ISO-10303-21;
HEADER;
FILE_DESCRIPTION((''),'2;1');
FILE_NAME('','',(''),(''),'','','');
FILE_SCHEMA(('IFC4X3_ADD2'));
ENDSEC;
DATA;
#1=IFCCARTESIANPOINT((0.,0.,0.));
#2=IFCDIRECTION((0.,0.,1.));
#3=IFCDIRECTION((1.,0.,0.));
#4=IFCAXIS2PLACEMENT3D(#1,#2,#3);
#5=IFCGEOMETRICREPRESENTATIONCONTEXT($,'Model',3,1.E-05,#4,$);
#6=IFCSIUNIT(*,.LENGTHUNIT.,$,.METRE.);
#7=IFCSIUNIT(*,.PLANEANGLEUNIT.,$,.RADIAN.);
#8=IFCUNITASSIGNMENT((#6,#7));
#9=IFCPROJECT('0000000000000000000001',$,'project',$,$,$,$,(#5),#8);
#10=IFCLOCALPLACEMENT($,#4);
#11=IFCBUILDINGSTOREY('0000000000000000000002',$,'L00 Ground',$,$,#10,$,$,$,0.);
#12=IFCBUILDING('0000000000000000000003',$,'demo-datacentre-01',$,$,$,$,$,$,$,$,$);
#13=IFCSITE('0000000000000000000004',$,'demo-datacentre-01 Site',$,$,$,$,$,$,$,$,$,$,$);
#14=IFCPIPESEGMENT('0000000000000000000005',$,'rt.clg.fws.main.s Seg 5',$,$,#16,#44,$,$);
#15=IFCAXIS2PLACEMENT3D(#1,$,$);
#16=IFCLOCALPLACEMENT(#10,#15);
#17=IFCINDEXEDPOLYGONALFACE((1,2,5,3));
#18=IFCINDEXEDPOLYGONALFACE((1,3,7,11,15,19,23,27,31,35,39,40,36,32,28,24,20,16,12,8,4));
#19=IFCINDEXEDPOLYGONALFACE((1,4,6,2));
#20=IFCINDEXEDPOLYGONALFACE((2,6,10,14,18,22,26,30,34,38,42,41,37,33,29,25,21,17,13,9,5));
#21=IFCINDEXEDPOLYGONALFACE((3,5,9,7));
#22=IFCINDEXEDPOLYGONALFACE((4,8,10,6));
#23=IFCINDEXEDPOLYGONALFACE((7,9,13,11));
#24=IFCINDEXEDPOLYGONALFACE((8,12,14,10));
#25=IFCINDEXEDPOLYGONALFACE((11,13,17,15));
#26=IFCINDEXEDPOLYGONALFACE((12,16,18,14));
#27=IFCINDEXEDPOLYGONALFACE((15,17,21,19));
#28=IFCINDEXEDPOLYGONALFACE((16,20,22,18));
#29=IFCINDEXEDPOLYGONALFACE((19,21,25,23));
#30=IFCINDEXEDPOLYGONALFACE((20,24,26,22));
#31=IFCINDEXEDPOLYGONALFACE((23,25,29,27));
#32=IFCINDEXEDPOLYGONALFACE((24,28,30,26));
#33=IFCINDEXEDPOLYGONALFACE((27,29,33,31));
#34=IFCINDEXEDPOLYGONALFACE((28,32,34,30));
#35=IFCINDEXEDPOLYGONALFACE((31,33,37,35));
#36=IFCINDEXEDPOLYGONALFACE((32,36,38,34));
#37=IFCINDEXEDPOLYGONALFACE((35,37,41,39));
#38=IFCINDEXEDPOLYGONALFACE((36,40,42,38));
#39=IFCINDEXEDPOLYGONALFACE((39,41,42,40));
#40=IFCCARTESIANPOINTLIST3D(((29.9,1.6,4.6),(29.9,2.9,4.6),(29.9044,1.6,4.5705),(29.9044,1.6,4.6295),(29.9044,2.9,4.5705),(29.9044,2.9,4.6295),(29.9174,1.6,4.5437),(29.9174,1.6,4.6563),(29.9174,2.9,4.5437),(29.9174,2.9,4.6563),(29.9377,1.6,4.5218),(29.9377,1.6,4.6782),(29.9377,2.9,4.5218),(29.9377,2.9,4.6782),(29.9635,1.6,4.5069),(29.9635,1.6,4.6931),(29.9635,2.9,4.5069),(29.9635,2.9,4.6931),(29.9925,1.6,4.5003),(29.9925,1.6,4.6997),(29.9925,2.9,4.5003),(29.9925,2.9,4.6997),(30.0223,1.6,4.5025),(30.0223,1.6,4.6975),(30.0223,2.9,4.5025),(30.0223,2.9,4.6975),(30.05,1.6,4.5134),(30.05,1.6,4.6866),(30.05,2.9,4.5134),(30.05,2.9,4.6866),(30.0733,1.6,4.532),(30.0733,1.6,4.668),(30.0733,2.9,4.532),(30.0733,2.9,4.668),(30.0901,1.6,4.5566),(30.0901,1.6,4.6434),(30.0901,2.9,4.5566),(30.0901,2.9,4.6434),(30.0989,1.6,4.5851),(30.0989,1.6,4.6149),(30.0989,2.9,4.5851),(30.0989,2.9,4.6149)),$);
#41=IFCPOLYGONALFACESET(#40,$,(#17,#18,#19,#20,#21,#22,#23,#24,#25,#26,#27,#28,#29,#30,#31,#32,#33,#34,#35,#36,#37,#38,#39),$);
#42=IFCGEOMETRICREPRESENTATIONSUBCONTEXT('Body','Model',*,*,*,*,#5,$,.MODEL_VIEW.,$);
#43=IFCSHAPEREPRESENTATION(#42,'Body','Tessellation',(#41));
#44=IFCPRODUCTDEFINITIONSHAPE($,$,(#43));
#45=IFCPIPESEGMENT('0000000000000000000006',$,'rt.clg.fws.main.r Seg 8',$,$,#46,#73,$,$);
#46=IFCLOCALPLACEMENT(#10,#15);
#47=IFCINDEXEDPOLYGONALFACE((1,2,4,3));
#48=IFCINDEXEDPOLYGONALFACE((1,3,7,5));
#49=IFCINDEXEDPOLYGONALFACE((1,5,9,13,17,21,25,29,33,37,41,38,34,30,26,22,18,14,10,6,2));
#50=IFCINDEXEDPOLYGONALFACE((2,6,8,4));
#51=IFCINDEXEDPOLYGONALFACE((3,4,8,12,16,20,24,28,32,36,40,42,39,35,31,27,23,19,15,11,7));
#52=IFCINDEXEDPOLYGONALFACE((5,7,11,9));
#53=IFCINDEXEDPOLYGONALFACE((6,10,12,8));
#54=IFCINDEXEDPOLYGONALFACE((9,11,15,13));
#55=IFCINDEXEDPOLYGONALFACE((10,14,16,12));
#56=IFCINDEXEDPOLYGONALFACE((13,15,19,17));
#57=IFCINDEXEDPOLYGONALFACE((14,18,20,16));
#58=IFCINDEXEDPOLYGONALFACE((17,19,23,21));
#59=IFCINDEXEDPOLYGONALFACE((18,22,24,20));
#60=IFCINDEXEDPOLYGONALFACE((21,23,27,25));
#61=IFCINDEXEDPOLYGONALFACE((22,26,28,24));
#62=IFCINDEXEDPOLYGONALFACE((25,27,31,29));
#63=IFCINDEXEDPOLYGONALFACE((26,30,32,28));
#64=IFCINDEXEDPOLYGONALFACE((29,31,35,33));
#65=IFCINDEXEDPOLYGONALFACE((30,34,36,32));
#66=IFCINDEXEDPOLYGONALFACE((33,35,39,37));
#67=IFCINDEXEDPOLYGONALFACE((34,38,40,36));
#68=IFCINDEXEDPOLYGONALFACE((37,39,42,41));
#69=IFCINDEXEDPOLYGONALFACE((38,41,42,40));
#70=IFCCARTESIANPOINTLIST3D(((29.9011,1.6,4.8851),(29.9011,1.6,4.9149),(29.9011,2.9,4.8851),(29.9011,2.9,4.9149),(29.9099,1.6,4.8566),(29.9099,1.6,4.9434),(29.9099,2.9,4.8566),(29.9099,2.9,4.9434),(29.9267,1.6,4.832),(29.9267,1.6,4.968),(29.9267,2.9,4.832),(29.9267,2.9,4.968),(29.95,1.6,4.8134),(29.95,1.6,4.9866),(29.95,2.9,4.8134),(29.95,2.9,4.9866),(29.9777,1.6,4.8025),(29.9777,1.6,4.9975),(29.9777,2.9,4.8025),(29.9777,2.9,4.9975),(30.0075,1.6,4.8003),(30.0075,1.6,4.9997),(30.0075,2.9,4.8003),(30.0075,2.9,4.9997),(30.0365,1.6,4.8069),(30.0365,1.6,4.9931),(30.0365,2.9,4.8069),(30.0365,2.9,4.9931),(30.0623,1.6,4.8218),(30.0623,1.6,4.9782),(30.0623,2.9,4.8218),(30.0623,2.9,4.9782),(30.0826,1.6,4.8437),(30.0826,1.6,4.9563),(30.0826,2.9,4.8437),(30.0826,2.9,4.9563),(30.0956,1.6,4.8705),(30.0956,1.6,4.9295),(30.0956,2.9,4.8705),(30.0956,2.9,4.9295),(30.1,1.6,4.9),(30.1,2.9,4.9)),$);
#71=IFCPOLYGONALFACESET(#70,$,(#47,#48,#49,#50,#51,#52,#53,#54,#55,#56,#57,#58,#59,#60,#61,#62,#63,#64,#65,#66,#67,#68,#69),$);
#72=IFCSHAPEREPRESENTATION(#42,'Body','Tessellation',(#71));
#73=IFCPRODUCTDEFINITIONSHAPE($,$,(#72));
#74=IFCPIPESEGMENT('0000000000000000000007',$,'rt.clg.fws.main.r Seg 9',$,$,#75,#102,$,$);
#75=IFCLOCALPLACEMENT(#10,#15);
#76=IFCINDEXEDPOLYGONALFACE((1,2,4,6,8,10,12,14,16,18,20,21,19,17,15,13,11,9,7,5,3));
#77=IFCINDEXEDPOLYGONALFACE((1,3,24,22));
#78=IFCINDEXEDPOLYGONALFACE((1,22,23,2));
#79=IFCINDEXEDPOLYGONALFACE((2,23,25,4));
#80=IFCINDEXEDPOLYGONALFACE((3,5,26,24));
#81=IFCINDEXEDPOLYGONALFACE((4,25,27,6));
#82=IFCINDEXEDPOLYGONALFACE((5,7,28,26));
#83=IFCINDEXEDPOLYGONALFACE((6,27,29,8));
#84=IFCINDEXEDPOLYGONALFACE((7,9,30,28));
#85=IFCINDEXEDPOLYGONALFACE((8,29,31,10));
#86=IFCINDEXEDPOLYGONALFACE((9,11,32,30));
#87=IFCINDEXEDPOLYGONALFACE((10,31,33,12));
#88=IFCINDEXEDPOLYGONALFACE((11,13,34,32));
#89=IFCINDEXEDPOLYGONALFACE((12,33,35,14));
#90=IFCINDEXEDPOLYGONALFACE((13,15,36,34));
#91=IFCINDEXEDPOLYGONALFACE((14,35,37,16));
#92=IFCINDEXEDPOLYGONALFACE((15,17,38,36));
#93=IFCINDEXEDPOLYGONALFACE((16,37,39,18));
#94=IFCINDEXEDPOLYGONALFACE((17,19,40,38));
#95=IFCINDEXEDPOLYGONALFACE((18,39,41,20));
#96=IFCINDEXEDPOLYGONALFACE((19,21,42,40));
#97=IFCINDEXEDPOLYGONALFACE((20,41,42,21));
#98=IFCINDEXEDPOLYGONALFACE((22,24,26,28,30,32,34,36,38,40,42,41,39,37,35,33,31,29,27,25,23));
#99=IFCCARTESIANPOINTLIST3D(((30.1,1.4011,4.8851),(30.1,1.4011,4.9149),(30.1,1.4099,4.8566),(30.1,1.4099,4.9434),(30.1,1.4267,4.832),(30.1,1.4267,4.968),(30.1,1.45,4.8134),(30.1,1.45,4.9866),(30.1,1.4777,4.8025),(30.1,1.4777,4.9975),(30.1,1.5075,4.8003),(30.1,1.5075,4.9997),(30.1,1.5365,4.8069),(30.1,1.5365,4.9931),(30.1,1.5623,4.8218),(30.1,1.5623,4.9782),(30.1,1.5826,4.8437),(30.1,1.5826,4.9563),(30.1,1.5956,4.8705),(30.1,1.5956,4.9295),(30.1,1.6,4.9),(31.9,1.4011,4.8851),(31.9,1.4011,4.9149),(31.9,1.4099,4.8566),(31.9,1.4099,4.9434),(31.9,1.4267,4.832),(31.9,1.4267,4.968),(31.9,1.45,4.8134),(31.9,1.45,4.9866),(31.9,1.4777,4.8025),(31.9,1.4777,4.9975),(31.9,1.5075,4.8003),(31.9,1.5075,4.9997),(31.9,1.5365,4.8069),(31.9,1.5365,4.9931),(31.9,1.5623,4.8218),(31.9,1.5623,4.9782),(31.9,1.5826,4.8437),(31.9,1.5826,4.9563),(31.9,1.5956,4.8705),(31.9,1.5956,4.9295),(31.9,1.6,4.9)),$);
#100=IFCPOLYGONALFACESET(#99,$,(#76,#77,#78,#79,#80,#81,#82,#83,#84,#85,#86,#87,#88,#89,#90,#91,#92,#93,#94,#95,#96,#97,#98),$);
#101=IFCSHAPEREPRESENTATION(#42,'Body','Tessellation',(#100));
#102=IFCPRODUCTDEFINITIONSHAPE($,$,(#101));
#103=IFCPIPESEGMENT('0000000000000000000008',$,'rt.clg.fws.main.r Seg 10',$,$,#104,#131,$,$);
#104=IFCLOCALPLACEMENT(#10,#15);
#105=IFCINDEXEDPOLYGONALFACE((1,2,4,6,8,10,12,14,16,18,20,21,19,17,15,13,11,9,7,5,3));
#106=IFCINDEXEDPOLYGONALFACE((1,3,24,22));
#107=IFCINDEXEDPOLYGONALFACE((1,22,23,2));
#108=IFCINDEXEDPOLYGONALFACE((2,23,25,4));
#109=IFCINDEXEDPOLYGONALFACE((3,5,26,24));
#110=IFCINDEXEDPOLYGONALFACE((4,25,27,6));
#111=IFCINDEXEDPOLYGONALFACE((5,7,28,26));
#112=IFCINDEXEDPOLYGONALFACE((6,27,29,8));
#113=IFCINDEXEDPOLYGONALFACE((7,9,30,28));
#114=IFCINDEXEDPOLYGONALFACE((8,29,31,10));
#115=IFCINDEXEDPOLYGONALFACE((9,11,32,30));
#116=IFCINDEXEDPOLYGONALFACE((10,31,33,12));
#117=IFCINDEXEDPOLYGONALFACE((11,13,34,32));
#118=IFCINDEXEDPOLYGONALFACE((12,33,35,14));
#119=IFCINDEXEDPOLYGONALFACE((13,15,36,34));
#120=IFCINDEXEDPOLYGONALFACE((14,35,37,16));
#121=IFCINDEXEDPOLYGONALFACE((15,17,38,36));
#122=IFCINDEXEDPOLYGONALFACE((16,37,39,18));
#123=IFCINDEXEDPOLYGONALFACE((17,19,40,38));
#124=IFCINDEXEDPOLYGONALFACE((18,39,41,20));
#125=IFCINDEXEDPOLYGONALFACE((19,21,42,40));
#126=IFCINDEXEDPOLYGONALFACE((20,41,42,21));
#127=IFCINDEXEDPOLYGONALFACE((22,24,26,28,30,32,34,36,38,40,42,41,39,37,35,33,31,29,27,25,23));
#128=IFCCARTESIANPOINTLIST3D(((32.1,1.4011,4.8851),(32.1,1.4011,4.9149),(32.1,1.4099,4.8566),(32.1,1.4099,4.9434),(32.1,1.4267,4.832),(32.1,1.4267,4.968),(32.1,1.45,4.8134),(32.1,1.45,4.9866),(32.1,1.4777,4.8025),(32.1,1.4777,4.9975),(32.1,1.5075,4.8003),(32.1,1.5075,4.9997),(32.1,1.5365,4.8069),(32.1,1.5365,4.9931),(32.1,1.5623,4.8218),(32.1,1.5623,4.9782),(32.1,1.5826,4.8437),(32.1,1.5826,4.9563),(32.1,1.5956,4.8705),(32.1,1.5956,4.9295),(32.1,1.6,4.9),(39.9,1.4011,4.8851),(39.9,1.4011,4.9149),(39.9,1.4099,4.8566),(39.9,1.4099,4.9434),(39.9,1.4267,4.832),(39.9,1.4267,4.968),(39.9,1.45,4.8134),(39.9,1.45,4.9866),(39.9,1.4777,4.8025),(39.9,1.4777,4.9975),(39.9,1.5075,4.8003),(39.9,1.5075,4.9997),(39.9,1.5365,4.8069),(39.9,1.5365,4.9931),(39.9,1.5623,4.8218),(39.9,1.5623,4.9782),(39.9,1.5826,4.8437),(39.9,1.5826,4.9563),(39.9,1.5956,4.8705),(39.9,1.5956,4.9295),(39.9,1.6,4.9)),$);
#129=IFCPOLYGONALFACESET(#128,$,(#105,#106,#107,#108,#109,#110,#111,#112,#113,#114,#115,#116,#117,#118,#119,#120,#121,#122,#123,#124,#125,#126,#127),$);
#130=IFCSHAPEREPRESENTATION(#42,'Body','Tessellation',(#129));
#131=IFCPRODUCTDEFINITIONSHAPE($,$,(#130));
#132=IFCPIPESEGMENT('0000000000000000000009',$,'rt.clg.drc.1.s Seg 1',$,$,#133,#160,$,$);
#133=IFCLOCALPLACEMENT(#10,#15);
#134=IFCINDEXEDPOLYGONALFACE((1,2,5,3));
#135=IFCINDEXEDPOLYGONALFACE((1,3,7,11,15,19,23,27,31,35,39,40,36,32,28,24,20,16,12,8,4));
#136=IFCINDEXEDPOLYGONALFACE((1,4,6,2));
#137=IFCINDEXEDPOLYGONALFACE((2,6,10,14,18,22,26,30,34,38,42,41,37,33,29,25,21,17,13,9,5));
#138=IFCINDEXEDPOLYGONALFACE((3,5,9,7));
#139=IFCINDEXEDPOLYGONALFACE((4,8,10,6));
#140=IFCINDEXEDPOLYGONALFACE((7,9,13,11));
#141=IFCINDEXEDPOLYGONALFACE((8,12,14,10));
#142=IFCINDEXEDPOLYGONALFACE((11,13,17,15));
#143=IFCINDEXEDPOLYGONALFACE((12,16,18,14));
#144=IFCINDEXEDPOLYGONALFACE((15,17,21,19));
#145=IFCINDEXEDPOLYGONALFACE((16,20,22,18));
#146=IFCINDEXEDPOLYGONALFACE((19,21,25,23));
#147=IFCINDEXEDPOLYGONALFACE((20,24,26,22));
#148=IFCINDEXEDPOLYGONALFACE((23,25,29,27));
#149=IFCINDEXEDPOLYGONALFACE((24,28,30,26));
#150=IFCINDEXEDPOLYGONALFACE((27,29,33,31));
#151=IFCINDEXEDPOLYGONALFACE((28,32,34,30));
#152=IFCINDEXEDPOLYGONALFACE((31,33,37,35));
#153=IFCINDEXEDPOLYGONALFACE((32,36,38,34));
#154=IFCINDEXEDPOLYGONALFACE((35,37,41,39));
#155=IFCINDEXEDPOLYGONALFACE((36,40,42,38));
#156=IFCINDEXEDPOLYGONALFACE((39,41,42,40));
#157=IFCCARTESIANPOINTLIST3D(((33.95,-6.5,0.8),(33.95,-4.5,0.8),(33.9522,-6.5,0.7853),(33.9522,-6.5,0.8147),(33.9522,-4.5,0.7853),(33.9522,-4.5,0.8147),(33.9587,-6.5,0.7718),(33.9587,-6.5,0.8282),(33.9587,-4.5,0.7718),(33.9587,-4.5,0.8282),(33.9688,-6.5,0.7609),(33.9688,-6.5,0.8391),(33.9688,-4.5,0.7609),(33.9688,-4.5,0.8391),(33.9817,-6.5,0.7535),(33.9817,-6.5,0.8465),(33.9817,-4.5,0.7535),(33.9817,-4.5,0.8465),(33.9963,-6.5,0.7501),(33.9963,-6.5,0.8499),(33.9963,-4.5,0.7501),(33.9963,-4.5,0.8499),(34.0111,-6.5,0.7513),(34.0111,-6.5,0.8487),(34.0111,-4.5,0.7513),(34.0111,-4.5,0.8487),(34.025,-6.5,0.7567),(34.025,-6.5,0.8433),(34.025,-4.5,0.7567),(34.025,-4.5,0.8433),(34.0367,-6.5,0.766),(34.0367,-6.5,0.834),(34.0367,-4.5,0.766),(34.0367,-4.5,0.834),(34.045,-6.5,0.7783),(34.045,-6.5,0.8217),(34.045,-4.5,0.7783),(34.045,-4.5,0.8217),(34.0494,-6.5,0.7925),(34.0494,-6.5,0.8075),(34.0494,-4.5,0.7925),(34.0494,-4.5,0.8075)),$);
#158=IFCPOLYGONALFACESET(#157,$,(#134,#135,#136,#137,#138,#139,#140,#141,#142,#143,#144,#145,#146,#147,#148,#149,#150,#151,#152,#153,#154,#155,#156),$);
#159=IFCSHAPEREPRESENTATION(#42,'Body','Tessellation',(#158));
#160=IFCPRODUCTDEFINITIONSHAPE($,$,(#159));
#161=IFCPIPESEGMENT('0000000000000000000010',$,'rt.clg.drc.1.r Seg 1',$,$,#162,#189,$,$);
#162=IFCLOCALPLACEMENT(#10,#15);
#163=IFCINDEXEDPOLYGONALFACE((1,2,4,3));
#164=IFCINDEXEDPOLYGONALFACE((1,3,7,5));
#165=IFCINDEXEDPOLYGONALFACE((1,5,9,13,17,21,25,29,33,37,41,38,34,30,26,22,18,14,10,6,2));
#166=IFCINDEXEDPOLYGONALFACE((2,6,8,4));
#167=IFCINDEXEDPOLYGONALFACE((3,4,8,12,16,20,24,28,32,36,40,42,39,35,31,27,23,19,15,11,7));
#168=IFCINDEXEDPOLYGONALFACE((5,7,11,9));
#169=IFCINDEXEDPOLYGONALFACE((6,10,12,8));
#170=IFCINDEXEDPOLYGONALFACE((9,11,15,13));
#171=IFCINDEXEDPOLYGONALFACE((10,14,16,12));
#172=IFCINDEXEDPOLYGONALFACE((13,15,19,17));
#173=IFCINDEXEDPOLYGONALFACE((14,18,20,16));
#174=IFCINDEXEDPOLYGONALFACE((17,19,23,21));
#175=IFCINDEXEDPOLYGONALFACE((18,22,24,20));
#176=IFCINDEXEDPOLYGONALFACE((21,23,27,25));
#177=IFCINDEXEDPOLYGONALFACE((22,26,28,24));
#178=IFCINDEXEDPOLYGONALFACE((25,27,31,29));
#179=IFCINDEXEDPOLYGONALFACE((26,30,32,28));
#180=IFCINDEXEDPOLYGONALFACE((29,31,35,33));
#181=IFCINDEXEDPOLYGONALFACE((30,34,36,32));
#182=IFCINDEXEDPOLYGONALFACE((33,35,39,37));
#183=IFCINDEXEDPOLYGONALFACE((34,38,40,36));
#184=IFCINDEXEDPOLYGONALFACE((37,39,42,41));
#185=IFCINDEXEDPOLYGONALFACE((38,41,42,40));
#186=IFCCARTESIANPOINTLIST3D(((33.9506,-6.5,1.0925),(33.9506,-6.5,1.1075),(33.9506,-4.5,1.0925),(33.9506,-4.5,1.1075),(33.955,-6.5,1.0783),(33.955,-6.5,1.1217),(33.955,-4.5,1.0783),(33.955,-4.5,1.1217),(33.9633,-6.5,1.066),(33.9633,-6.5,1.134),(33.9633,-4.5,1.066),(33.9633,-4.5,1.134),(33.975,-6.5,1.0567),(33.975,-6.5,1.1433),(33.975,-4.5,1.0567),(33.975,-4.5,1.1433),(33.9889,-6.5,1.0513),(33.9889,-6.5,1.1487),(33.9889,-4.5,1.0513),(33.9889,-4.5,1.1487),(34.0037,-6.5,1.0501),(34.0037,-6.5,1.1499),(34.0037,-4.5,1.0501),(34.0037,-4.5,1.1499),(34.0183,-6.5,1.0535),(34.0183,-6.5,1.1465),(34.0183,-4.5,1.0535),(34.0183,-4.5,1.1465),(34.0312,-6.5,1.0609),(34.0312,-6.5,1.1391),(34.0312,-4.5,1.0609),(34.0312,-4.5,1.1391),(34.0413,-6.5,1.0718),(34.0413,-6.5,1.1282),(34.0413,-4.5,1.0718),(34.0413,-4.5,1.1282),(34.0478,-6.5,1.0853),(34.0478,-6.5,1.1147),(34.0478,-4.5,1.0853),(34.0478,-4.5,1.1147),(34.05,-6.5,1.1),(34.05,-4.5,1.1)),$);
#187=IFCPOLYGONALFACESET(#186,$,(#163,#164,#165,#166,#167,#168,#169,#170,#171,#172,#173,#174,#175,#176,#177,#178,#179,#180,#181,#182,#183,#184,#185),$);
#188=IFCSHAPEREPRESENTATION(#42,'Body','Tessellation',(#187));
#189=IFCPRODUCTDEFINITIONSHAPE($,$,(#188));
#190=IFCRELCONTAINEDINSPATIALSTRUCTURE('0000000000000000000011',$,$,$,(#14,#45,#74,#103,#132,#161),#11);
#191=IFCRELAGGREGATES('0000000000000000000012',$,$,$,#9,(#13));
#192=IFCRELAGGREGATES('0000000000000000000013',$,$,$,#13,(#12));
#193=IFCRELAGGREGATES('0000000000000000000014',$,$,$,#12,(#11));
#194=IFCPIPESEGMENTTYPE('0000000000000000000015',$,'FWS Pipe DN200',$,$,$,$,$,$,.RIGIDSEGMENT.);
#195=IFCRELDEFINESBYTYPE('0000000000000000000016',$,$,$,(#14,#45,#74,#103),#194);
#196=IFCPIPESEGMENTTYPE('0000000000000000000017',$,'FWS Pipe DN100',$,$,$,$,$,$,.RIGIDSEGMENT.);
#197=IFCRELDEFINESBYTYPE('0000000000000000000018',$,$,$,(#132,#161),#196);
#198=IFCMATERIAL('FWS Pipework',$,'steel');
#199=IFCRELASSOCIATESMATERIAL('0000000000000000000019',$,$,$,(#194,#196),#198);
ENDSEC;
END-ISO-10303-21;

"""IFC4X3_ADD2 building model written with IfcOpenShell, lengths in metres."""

from ifc_helpers import new_model, si_unit, frame, origin_with_axes, place, context, subcontext, project, spatial, circle, extrude, material, type_object, element, save


model = new_model("IFC4X3_ADD2")

# Units and contexts
model_context = context("Model", 3, precision=1e-05, world=origin_with_axes())
body_context = subcontext(model_context, "Body", "Model", "MODEL_VIEW")
ifc_project = project(units=[si_unit("LENGTHUNIT", "METRE"), si_unit("PLANEANGLEUNIT", "RADIAN")], contexts=[model_context])

# Site, building, storey
site = spatial("IfcSite", under=ifc_project, Name="demo-datacentre-01 Site")
building = spatial("IfcBuilding", under=site, Name="demo-datacentre-01")
storey_placement = place(None, origin_with_axes())
storey = spatial("IfcBuildingStorey", under=building, at=storey_placement, Name="L00 Ground", Elevation=0.0)

# Shared definitions
ifc_material = material(Name="FWS Pipework", Category="steel")

# Pipe segments
pipe_segment_type_1 = type_object("IfcPipeSegmentType", Name="FWS Pipe DN200", PredefinedType="RIGIDSEGMENT", material=ifc_material)
for number, where, z_axis, x_axis, name in (
    (1, (30.0, 1.6, 4.6), (0.0, 1.0, 0.0), (-1.0, 0.0, 0.0), "rt.clg.fws.main.s Seg 5"),
    (2, (30.0, 2.9, 4.9), (0.0, -1.0, 0.0), (1.0, 0.0, 0.0), "rt.clg.fws.main.r Seg 8"),
):
    element("IfcPipeSegment", number, at=place(storey_placement, frame(where, z_axis=z_axis, x_axis=x_axis)), inside=storey, type_object=pipe_segment_type_1, Name=name, context=body_context, shape_type="SweptSolid", body=[
        extrude(circle(Radius=0.1), origin_with_axes(), (0.0, 0.0, 1.0), 1.3),
    ])
pipe_segment_1_placement = place(storey_placement, frame((30.1, 1.5, 4.9), z_axis=(1.0, 0.0, 0.0), x_axis=(0.0, 1.0, 0.0)))
element("IfcPipeSegment", 3, at=pipe_segment_1_placement, inside=storey, type_object=pipe_segment_type_1, Name="rt.clg.fws.main.r Seg 9", context=body_context, shape_type="SweptSolid", body=[
    extrude(circle(Radius=0.1), origin_with_axes(), (0.0, 0.0, 1.0), 1.8),
])
pipe_segment_2_placement = place(storey_placement, frame((32.1, 1.5, 4.9), z_axis=(1.0, 0.0, 0.0), x_axis=(0.0, 1.0, 0.0)))
element("IfcPipeSegment", 4, at=pipe_segment_2_placement, inside=storey, type_object=pipe_segment_type_1, Name="rt.clg.fws.main.r Seg 10", context=body_context, shape_type="SweptSolid", body=[
    extrude(circle(Radius=0.1), origin_with_axes(), (0.0, 0.0, 1.0), 7.8),
])
pipe_segment_type_2 = type_object("IfcPipeSegmentType", Name="FWS Pipe DN100", PredefinedType="RIGIDSEGMENT", material=ifc_material)
for number, where, z_axis, x_axis, name in (
    (5, (34.0, -6.5, 0.8), (0.0, 1.0, 0.0), (-1.0, 0.0, 0.0), "rt.clg.drc.1.s Seg 1"),
    (6, (34.0, -4.5, 1.1), (0.0, -1.0, 0.0), (1.0, 0.0, 0.0), "rt.clg.drc.1.r Seg 1"),
):
    element("IfcPipeSegment", number, at=place(storey_placement, frame(where, z_axis=z_axis, x_axis=x_axis)), inside=storey, type_object=pipe_segment_type_2, Name=name, context=body_context, shape_type="SweptSolid", body=[
        extrude(circle(Radius=0.05), origin_with_axes(), (0.0, 0.0, 1.0), 2.0),
    ])

save(model, "model.ifc")
